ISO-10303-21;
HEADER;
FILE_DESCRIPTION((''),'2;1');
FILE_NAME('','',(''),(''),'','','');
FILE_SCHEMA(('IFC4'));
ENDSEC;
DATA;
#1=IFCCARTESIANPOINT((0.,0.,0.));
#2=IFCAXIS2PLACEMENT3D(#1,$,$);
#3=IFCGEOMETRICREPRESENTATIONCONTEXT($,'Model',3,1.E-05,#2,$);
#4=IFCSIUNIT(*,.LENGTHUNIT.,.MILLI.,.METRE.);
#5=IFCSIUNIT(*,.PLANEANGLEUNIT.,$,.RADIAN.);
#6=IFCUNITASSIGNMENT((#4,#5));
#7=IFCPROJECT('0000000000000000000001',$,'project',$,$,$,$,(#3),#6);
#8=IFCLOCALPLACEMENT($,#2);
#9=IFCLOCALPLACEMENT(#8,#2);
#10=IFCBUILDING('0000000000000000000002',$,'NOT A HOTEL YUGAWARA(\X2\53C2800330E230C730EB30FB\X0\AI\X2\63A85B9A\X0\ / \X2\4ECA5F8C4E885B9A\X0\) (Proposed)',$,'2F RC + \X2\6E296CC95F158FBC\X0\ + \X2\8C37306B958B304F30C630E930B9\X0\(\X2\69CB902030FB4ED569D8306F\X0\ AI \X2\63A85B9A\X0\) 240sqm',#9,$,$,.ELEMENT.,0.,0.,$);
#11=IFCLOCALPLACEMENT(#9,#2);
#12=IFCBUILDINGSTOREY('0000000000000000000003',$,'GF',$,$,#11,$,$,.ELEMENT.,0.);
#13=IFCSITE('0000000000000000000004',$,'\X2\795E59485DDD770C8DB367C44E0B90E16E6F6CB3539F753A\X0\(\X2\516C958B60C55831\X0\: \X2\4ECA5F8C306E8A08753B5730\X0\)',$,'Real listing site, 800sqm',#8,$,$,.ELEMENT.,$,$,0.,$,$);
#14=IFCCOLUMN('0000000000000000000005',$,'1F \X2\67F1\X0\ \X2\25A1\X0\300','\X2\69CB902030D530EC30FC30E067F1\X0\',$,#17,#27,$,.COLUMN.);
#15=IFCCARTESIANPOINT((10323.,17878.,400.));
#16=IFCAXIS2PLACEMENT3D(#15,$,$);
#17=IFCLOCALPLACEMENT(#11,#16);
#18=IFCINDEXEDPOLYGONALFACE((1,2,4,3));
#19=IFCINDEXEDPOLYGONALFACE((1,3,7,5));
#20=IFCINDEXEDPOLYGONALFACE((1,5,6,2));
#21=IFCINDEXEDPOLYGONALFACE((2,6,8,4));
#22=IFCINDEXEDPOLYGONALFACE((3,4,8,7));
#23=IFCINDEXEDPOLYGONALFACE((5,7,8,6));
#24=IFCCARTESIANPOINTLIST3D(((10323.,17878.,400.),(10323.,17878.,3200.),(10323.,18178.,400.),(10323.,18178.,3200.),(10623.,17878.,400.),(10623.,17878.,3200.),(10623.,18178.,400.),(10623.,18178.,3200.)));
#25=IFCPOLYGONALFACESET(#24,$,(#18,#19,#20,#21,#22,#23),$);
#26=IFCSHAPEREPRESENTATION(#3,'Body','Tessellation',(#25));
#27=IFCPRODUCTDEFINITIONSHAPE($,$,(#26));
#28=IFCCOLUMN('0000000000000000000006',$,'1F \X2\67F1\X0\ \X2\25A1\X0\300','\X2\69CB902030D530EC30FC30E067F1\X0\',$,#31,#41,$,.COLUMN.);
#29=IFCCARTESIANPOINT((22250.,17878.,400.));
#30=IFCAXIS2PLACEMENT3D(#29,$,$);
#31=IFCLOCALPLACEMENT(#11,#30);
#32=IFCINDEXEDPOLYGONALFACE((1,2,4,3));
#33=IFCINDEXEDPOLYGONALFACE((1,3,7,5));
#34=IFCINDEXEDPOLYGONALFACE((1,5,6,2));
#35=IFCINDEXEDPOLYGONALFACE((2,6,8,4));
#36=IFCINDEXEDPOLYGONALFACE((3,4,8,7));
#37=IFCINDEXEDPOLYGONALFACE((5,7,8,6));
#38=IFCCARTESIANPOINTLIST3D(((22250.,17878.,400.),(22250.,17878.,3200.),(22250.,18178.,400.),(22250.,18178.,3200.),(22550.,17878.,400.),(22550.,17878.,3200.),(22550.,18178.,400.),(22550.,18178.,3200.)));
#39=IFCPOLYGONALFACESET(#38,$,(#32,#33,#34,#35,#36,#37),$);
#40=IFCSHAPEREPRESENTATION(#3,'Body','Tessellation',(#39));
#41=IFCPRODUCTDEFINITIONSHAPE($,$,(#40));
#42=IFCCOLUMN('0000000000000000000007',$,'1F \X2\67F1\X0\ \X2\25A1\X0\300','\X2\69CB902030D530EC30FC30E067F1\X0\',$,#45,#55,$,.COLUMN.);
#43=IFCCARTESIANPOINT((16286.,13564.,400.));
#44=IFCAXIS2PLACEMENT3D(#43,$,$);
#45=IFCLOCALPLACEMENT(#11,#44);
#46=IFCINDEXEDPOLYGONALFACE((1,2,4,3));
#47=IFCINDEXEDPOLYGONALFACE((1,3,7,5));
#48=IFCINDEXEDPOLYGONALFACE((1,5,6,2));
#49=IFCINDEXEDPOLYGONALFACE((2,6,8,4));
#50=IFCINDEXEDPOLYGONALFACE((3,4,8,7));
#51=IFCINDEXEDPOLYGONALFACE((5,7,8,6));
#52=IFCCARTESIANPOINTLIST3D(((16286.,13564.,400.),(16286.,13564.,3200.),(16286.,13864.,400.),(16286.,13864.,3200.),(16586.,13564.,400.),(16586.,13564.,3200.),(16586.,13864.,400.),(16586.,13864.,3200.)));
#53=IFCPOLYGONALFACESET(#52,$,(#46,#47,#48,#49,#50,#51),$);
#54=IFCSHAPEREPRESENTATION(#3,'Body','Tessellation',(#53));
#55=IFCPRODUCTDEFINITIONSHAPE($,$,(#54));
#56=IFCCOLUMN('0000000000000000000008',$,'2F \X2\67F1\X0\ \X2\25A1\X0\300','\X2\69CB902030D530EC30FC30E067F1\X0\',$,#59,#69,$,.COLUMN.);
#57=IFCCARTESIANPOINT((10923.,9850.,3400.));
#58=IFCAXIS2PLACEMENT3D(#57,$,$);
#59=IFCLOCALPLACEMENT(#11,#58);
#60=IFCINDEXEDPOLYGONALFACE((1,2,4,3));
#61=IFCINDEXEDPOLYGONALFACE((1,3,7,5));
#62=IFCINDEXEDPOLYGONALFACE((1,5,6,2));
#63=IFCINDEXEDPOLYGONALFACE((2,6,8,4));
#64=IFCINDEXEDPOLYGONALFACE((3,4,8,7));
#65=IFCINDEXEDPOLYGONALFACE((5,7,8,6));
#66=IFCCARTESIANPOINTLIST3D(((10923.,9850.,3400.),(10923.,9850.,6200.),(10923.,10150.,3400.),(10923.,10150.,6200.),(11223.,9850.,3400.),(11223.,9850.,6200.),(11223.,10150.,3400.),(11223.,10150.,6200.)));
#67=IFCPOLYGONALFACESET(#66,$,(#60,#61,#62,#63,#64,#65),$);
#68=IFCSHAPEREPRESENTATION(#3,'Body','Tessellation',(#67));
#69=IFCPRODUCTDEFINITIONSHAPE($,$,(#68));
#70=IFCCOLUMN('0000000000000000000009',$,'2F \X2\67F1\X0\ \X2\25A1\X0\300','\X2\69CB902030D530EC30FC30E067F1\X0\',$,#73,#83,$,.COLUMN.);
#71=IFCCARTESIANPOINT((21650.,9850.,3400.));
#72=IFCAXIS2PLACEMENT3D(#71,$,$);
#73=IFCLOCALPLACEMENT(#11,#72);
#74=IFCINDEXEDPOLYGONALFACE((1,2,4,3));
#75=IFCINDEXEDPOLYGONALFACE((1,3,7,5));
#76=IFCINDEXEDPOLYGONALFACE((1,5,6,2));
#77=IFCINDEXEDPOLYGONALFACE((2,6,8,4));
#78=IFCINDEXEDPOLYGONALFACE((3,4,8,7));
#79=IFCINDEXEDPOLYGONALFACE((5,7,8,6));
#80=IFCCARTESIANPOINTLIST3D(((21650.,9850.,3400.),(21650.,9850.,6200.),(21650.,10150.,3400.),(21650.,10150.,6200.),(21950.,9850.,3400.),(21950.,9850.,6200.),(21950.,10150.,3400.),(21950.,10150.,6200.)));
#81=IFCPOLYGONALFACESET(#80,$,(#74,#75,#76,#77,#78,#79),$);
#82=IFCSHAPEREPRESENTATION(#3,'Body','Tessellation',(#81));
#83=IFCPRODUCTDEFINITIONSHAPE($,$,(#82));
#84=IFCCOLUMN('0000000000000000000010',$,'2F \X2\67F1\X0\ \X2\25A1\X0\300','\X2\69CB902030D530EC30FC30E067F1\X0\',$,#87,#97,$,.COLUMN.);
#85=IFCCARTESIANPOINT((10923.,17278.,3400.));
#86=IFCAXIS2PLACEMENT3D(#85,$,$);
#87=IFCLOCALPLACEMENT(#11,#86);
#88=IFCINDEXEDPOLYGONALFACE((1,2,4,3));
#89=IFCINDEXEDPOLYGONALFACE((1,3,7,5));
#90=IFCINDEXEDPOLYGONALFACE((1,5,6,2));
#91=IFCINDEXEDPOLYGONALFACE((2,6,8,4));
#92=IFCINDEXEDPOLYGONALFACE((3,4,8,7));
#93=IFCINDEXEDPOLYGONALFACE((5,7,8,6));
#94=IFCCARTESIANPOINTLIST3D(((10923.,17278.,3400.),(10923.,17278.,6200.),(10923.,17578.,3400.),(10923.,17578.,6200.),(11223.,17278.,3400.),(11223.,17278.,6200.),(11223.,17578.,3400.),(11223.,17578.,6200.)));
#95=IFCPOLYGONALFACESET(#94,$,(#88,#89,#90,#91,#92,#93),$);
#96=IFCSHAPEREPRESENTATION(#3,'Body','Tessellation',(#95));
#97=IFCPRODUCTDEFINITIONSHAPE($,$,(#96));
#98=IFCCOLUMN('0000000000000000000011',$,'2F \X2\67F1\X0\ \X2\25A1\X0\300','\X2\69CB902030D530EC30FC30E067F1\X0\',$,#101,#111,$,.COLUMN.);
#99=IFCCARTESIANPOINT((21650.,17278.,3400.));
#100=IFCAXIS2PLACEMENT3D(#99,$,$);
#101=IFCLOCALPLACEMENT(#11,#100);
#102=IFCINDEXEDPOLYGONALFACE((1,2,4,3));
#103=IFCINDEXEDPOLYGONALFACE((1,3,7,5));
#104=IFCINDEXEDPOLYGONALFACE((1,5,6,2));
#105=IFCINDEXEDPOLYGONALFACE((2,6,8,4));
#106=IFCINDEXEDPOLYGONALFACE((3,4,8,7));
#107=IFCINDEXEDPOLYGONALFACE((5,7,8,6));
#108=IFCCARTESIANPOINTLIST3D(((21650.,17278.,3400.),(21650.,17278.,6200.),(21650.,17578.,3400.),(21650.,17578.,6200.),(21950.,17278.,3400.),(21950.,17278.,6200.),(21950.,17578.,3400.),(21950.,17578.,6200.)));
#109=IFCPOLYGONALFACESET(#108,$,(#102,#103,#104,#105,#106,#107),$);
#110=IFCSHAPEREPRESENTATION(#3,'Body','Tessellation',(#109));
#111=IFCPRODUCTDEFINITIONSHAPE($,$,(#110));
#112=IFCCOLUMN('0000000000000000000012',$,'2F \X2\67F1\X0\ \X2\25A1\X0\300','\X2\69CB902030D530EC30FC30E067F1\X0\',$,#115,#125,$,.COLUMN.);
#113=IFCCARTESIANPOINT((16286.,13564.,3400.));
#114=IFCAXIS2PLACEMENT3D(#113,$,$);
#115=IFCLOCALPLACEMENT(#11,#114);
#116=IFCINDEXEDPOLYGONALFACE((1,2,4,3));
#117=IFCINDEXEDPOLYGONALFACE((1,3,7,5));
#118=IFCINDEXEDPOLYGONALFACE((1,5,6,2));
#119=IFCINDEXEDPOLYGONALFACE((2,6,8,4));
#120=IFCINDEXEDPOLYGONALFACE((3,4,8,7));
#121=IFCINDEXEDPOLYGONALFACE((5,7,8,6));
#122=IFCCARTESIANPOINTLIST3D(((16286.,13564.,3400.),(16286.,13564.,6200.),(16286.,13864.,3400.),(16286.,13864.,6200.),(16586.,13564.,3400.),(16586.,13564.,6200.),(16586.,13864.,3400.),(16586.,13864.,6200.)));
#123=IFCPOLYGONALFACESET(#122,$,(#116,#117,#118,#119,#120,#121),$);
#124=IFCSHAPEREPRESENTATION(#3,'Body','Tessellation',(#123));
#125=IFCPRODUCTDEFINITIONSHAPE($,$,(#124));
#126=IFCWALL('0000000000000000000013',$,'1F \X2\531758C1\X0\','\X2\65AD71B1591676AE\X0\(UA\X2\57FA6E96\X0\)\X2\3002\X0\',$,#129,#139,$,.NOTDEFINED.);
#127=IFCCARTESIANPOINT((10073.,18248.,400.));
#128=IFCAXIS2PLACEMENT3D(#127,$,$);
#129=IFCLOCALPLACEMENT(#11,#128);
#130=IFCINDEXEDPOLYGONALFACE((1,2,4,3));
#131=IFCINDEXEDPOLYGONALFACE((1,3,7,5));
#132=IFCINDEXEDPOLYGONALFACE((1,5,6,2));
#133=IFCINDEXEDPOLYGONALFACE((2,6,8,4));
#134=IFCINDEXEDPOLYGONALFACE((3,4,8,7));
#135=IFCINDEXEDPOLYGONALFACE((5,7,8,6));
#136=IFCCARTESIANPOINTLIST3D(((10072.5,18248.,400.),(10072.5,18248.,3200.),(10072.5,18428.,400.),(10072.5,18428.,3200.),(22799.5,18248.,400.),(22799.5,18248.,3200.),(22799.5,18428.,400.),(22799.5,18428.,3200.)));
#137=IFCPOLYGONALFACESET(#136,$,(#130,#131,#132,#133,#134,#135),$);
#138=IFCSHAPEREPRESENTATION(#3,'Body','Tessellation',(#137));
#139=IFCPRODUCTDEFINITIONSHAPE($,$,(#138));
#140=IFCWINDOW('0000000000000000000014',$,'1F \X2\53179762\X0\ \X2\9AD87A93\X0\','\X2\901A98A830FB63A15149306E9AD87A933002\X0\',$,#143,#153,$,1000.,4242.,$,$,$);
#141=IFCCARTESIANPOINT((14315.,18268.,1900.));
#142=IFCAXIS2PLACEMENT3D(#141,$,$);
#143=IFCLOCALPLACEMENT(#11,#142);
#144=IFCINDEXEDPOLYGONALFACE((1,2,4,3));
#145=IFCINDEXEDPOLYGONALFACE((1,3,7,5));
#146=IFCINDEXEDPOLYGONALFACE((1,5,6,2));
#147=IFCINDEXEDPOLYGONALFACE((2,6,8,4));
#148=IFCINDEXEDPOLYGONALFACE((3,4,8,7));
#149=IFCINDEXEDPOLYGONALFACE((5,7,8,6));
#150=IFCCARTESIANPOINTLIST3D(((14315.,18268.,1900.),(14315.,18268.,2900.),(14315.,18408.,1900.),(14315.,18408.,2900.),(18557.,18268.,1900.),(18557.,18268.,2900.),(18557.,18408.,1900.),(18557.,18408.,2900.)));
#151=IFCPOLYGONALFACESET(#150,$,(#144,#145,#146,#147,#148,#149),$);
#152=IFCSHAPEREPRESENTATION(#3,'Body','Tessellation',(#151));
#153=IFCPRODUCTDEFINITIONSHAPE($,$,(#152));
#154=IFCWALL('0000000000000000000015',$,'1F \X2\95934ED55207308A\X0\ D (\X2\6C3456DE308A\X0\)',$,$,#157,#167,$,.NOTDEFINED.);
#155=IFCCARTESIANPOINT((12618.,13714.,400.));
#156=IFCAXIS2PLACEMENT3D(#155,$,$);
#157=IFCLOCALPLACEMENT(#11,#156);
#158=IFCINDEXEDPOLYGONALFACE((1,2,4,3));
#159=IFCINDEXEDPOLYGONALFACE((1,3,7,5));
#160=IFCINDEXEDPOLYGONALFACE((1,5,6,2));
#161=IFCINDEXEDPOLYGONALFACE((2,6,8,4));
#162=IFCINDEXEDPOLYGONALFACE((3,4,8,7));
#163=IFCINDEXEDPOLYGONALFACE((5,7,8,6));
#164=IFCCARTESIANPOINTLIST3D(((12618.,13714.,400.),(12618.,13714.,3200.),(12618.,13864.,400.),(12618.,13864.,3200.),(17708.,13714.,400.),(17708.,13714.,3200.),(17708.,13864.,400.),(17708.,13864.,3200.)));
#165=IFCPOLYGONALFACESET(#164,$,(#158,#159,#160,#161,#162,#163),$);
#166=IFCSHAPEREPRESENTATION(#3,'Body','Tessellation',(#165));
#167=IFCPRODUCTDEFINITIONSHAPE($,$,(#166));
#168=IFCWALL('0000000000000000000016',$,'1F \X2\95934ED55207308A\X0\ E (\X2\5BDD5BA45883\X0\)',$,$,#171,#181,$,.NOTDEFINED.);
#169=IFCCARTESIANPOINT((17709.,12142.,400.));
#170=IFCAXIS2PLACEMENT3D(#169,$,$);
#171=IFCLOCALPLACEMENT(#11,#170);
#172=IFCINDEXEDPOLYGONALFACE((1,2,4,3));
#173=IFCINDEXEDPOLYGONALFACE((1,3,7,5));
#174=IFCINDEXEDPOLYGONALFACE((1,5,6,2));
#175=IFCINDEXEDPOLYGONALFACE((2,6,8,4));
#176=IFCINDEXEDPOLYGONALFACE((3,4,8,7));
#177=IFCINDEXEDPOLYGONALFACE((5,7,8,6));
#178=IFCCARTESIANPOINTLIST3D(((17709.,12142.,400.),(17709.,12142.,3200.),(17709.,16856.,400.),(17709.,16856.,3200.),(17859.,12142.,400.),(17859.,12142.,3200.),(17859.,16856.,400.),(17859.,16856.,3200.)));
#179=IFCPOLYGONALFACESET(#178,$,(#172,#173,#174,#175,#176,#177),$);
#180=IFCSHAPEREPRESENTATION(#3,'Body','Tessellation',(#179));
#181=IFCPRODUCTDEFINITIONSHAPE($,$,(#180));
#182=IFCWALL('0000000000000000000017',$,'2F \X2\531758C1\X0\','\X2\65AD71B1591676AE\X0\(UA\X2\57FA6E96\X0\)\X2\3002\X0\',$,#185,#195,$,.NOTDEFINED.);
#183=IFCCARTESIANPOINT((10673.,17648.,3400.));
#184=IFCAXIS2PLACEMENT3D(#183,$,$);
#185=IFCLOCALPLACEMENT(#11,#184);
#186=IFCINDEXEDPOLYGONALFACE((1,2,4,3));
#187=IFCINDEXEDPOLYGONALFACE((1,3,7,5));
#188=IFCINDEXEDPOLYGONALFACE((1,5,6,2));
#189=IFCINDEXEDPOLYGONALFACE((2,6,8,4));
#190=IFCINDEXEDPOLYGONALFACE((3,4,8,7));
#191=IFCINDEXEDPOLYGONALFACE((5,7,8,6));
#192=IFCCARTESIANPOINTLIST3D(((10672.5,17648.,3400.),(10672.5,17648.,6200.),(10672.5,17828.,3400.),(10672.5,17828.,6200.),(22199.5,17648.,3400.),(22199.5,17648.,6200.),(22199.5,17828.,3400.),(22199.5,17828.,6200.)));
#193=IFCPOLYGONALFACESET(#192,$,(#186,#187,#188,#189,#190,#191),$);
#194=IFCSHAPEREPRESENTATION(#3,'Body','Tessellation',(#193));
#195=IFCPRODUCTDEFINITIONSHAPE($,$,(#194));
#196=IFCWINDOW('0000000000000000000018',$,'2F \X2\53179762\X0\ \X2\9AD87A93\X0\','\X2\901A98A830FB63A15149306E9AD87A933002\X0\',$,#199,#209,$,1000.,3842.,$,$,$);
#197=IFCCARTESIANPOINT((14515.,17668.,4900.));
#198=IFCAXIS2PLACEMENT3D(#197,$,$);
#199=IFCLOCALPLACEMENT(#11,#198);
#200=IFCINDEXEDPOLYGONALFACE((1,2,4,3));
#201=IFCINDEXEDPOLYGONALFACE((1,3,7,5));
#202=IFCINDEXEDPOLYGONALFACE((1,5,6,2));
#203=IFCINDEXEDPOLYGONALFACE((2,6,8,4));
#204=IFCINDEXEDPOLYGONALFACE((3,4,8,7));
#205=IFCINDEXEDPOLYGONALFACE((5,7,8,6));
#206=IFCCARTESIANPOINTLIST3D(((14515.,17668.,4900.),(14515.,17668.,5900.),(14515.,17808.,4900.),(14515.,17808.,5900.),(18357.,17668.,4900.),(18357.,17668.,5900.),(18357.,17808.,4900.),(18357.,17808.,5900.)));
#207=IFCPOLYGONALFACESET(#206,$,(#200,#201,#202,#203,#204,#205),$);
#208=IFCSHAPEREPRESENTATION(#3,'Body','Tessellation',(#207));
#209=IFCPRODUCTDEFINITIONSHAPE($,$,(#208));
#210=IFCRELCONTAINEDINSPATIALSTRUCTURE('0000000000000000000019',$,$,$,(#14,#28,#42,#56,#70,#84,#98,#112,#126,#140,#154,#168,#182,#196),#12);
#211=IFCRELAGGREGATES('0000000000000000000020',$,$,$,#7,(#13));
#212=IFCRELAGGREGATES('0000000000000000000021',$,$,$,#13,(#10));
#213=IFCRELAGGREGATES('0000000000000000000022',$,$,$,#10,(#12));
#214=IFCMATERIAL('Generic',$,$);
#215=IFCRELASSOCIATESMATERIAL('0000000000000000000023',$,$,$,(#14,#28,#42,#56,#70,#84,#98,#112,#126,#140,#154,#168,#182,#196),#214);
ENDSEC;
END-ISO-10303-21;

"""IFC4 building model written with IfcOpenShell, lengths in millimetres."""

from ifc_helpers import new_model, si_unit, frame, frame_2d, origin, place, context, project, spatial, rectangle, extrude, material, element, fill, save


model = new_model("IFC4")

# Units and contexts
model_context = context("Model", 3, precision=1e-05, world=origin())
ifc_project = project(units=[si_unit("LENGTHUNIT", "METRE", prefix="MILLI"), si_unit("PLANEANGLEUNIT", "RADIAN")], contexts=[model_context])

# Site, building, storey
site_placement = place(None, origin())
site = spatial("IfcSite", under=ifc_project, at=site_placement, Name="神奈川県足柄下郡湯河原町(公開情報: 今後の計画地)", ObjectType="Real listing site, 800sqm", CompositionType="ELEMENT", RefElevation=0.0)
building_placement = place(site_placement, origin())
building = spatial("IfcBuilding", under=site, at=building_placement, Name="NOT A HOTEL YUGAWARA(参考モデル・AI推定 / 今後予定) (Proposed)", ObjectType="2F RC + 温泉引込 + 谷に開くテラス(構造・仕様は AI 推定) 240sqm", CompositionType="ELEMENT", ElevationOfRefHeight=0.0, ElevationOfTerrain=0.0)
storey_placement = place(building_placement, origin())
storey = spatial("IfcBuildingStorey", under=building, at=storey_placement, Name="GF", CompositionType="ELEMENT", Elevation=0.0)

# Columns
ifc_material_1 = material(Name="Generic")
column_1_placement = place(storey_placement, frame((10323.0, 17878.0, 400.0)))
element("IfcColumn", 1, at=column_1_placement, inside=storey, material=ifc_material_1, Name="1F 柱 □300", Description="構造フレーム柱", PredefinedType="COLUMN", context=model_context, shape_type="SweptSolid", body=[
    extrude(rectangle(XDim=300.0, YDim=300.0, at=frame_2d((150.0, 150.0))), frame((10323.0, 17878.0, 400.0)), (0.0, 0.0, 1.0), 2800.0),
])
column_2_placement = place(storey_placement, frame((22250.0, 17878.0, 400.0)))
element("IfcColumn", 2, at=column_2_placement, inside=storey, material=ifc_material_1, Name="1F 柱 □300", Description="構造フレーム柱", PredefinedType="COLUMN", context=model_context, shape_type="SweptSolid", body=[
    extrude(rectangle(XDim=300.0, YDim=300.0, at=frame_2d((150.0, 150.0))), frame((22250.0, 17878.0, 400.0)), (0.0, 0.0, 1.0), 2800.0),
])
column_3_placement = place(storey_placement, frame((16286.0, 13564.0, 400.0)))
element("IfcColumn", 3, at=column_3_placement, inside=storey, material=ifc_material_1, Name="1F 柱 □300", Description="構造フレーム柱", PredefinedType="COLUMN", context=model_context, shape_type="SweptSolid", body=[
    extrude(rectangle(XDim=300.0, YDim=300.0, at=frame_2d((150.0, 150.0))), frame((16286.0, 13564.0, 400.0)), (0.0, 0.0, 1.0), 2800.0),
])
column_4_placement = place(storey_placement, frame((10923.0, 9850.0, 3400.0)))
element("IfcColumn", 4, at=column_4_placement, inside=storey, material=ifc_material_1, Name="2F 柱 □300", Description="構造フレーム柱", PredefinedType="COLUMN", context=model_context, shape_type="SweptSolid", body=[
    extrude(rectangle(XDim=300.0, YDim=300.0, at=frame_2d((150.0, 150.0))), frame((10923.0, 9850.0, 3400.0)), (0.0, 0.0, 1.0), 2800.0),
])
column_5_placement = place(storey_placement, frame((21650.0, 9850.0, 3400.0)))
element("IfcColumn", 5, at=column_5_placement, inside=storey, material=ifc_material_1, Name="2F 柱 □300", Description="構造フレーム柱", PredefinedType="COLUMN", context=model_context, shape_type="SweptSolid", body=[
    extrude(rectangle(XDim=300.0, YDim=300.0, at=frame_2d((150.0, 150.0))), frame((21650.0, 9850.0, 3400.0)), (0.0, 0.0, 1.0), 2800.0),
])
column_6_placement = place(storey_placement, frame((10923.0, 17278.0, 3400.0)))
element("IfcColumn", 6, at=column_6_placement, inside=storey, material=ifc_material_1, Name="2F 柱 □300", Description="構造フレーム柱", PredefinedType="COLUMN", context=model_context, shape_type="SweptSolid", body=[
    extrude(rectangle(XDim=300.0, YDim=300.0, at=frame_2d((150.0, 150.0))), frame((10923.0, 17278.0, 3400.0)), (0.0, 0.0, 1.0), 2800.0),
])
column_7_placement = place(storey_placement, frame((21650.0, 17278.0, 3400.0)))
element("IfcColumn", 7, at=column_7_placement, inside=storey, material=ifc_material_1, Name="2F 柱 □300", Description="構造フレーム柱", PredefinedType="COLUMN", context=model_context, shape_type="SweptSolid", body=[
    extrude(rectangle(XDim=300.0, YDim=300.0, at=frame_2d((150.0, 150.0))), frame((21650.0, 17278.0, 3400.0)), (0.0, 0.0, 1.0), 2800.0),
])
column_8_placement = place(storey_placement, frame((16286.0, 13564.0, 3400.0)))
element("IfcColumn", 8, at=column_8_placement, inside=storey, material=ifc_material_1, Name="2F 柱 □300", Description="構造フレーム柱", PredefinedType="COLUMN", context=model_context, shape_type="SweptSolid", body=[
    extrude(rectangle(XDim=300.0, YDim=300.0, at=frame_2d((150.0, 150.0))), frame((16286.0, 13564.0, 3400.0)), (0.0, 0.0, 1.0), 2800.0),
])

# Wall, opening, window
wall_1_placement = place(storey_placement, frame((10073.0, 18248.0, 400.0)))
wall_1 = element("IfcWall", 9, at=wall_1_placement, inside=storey, material=ifc_material_1, Name="1F 北壁", Description="断熱外皮(UA基準)。", PredefinedType="NOTDEFINED", context=model_context, shape_type="SweptSolid", body=[
    extrude(rectangle(XDim=12727.0, YDim=180.0, at=frame_2d((6363.0, 90.0))), frame((10073.0, 18248.0, 400.0)), (0.0, 0.0, 1.0), 2800.0),
])
opening_1_placement = place(storey_placement, frame((14315.0, 18268.0, 1900.0)))
opening_1 = element("IfcOpeningElement", 10, at=opening_1_placement, cuts=wall_1, PredefinedType="NOTDEFINED", context=model_context, shape_type="SweptSolid", body=[
    extrude(rectangle(XDim=4242.0, YDim=140.0, at=frame_2d((2121.0, 70.0))), frame((14315.0, 18268.0, 1900.0)), (0.0, 0.0, 1.0), 1000.0),
])
window_1_placement = place(storey_placement, frame((14315.0, 18268.0, 1900.0)))
window_1 = element("IfcWindow", 11, at=window_1_placement, inside=storey, material=ifc_material_1, Name="1F 北面 高窓", Description="通風・採光の高窓。", OverallHeight=1000.0, OverallWidth=4242.0, context=model_context, shape_type="SweptSolid", body=[
    extrude(rectangle(XDim=4242.0, YDim=140.0, at=frame_2d((2121.0, 70.0))), frame((14315.0, 18268.0, 1900.0)), (0.0, 0.0, 1.0), 1000.0),
])
fill(opening_1, window_1)

# Walls
wall_2_placement = place(storey_placement, frame((12618.0, 13714.0, 400.0)))
element("IfcWall", 12, at=wall_2_placement, inside=storey, material=ifc_material_1, Name="1F 間仕切り D (水回り)", PredefinedType="NOTDEFINED", context=model_context, shape_type="SweptSolid", body=[
    extrude(rectangle(XDim=5090.0, YDim=150.0, at=frame_2d((2545.0, 75.0))), frame((12618.0, 13714.0, 400.0)), (0.0, 0.0, 1.0), 2800.0),
])
wall_3_placement = place(storey_placement, frame((17709.0, 12142.0, 400.0)))
element("IfcWall", 13, at=wall_3_placement, inside=storey, material=ifc_material_1, Name="1F 間仕切り E (寝室境)", PredefinedType="NOTDEFINED", context=model_context, shape_type="SweptSolid", body=[
    extrude(rectangle(XDim=150.0, YDim=4714.0, at=frame_2d((75.0, 2357.0))), frame((17709.0, 12142.0, 400.0)), (0.0, 0.0, 1.0), 2800.0),
])

# Wall, opening, window
wall_4_placement = place(storey_placement, frame((10673.0, 17648.0, 3400.0)))
wall_4 = element("IfcWall", 14, at=wall_4_placement, inside=storey, material=ifc_material_1, Name="2F 北壁", Description="断熱外皮(UA基準)。", PredefinedType="NOTDEFINED", context=model_context, shape_type="SweptSolid", body=[
    extrude(rectangle(XDim=11527.0, YDim=180.0, at=frame_2d((5763.0, 90.0))), frame((10673.0, 17648.0, 3400.0)), (0.0, 0.0, 1.0), 2800.0),
])
opening_2_placement = place(storey_placement, frame((14515.0, 17668.0, 4900.0)))
opening_2 = element("IfcOpeningElement", 15, at=opening_2_placement, cuts=wall_4, PredefinedType="NOTDEFINED", context=model_context, shape_type="SweptSolid", body=[
    extrude(rectangle(XDim=3842.0, YDim=140.0, at=frame_2d((1921.0, 70.0))), frame((14515.0, 17668.0, 4900.0)), (0.0, 0.0, 1.0), 1000.0),
])
window_2_placement = place(storey_placement, frame((14515.0, 17668.0, 4900.0)))
window_2 = element("IfcWindow", 16, at=window_2_placement, inside=storey, material=ifc_material_1, Name="2F 北面 高窓", Description="通風・採光の高窓。", OverallHeight=1000.0, OverallWidth=3842.0, context=model_context, shape_type="SweptSolid", body=[
    extrude(rectangle(XDim=3842.0, YDim=140.0, at=frame_2d((1921.0, 70.0))), frame((14515.0, 17668.0, 4900.0)), (0.0, 0.0, 1.0), 1000.0),
])
fill(opening_2, window_2)

save(model, "model.ifc")
